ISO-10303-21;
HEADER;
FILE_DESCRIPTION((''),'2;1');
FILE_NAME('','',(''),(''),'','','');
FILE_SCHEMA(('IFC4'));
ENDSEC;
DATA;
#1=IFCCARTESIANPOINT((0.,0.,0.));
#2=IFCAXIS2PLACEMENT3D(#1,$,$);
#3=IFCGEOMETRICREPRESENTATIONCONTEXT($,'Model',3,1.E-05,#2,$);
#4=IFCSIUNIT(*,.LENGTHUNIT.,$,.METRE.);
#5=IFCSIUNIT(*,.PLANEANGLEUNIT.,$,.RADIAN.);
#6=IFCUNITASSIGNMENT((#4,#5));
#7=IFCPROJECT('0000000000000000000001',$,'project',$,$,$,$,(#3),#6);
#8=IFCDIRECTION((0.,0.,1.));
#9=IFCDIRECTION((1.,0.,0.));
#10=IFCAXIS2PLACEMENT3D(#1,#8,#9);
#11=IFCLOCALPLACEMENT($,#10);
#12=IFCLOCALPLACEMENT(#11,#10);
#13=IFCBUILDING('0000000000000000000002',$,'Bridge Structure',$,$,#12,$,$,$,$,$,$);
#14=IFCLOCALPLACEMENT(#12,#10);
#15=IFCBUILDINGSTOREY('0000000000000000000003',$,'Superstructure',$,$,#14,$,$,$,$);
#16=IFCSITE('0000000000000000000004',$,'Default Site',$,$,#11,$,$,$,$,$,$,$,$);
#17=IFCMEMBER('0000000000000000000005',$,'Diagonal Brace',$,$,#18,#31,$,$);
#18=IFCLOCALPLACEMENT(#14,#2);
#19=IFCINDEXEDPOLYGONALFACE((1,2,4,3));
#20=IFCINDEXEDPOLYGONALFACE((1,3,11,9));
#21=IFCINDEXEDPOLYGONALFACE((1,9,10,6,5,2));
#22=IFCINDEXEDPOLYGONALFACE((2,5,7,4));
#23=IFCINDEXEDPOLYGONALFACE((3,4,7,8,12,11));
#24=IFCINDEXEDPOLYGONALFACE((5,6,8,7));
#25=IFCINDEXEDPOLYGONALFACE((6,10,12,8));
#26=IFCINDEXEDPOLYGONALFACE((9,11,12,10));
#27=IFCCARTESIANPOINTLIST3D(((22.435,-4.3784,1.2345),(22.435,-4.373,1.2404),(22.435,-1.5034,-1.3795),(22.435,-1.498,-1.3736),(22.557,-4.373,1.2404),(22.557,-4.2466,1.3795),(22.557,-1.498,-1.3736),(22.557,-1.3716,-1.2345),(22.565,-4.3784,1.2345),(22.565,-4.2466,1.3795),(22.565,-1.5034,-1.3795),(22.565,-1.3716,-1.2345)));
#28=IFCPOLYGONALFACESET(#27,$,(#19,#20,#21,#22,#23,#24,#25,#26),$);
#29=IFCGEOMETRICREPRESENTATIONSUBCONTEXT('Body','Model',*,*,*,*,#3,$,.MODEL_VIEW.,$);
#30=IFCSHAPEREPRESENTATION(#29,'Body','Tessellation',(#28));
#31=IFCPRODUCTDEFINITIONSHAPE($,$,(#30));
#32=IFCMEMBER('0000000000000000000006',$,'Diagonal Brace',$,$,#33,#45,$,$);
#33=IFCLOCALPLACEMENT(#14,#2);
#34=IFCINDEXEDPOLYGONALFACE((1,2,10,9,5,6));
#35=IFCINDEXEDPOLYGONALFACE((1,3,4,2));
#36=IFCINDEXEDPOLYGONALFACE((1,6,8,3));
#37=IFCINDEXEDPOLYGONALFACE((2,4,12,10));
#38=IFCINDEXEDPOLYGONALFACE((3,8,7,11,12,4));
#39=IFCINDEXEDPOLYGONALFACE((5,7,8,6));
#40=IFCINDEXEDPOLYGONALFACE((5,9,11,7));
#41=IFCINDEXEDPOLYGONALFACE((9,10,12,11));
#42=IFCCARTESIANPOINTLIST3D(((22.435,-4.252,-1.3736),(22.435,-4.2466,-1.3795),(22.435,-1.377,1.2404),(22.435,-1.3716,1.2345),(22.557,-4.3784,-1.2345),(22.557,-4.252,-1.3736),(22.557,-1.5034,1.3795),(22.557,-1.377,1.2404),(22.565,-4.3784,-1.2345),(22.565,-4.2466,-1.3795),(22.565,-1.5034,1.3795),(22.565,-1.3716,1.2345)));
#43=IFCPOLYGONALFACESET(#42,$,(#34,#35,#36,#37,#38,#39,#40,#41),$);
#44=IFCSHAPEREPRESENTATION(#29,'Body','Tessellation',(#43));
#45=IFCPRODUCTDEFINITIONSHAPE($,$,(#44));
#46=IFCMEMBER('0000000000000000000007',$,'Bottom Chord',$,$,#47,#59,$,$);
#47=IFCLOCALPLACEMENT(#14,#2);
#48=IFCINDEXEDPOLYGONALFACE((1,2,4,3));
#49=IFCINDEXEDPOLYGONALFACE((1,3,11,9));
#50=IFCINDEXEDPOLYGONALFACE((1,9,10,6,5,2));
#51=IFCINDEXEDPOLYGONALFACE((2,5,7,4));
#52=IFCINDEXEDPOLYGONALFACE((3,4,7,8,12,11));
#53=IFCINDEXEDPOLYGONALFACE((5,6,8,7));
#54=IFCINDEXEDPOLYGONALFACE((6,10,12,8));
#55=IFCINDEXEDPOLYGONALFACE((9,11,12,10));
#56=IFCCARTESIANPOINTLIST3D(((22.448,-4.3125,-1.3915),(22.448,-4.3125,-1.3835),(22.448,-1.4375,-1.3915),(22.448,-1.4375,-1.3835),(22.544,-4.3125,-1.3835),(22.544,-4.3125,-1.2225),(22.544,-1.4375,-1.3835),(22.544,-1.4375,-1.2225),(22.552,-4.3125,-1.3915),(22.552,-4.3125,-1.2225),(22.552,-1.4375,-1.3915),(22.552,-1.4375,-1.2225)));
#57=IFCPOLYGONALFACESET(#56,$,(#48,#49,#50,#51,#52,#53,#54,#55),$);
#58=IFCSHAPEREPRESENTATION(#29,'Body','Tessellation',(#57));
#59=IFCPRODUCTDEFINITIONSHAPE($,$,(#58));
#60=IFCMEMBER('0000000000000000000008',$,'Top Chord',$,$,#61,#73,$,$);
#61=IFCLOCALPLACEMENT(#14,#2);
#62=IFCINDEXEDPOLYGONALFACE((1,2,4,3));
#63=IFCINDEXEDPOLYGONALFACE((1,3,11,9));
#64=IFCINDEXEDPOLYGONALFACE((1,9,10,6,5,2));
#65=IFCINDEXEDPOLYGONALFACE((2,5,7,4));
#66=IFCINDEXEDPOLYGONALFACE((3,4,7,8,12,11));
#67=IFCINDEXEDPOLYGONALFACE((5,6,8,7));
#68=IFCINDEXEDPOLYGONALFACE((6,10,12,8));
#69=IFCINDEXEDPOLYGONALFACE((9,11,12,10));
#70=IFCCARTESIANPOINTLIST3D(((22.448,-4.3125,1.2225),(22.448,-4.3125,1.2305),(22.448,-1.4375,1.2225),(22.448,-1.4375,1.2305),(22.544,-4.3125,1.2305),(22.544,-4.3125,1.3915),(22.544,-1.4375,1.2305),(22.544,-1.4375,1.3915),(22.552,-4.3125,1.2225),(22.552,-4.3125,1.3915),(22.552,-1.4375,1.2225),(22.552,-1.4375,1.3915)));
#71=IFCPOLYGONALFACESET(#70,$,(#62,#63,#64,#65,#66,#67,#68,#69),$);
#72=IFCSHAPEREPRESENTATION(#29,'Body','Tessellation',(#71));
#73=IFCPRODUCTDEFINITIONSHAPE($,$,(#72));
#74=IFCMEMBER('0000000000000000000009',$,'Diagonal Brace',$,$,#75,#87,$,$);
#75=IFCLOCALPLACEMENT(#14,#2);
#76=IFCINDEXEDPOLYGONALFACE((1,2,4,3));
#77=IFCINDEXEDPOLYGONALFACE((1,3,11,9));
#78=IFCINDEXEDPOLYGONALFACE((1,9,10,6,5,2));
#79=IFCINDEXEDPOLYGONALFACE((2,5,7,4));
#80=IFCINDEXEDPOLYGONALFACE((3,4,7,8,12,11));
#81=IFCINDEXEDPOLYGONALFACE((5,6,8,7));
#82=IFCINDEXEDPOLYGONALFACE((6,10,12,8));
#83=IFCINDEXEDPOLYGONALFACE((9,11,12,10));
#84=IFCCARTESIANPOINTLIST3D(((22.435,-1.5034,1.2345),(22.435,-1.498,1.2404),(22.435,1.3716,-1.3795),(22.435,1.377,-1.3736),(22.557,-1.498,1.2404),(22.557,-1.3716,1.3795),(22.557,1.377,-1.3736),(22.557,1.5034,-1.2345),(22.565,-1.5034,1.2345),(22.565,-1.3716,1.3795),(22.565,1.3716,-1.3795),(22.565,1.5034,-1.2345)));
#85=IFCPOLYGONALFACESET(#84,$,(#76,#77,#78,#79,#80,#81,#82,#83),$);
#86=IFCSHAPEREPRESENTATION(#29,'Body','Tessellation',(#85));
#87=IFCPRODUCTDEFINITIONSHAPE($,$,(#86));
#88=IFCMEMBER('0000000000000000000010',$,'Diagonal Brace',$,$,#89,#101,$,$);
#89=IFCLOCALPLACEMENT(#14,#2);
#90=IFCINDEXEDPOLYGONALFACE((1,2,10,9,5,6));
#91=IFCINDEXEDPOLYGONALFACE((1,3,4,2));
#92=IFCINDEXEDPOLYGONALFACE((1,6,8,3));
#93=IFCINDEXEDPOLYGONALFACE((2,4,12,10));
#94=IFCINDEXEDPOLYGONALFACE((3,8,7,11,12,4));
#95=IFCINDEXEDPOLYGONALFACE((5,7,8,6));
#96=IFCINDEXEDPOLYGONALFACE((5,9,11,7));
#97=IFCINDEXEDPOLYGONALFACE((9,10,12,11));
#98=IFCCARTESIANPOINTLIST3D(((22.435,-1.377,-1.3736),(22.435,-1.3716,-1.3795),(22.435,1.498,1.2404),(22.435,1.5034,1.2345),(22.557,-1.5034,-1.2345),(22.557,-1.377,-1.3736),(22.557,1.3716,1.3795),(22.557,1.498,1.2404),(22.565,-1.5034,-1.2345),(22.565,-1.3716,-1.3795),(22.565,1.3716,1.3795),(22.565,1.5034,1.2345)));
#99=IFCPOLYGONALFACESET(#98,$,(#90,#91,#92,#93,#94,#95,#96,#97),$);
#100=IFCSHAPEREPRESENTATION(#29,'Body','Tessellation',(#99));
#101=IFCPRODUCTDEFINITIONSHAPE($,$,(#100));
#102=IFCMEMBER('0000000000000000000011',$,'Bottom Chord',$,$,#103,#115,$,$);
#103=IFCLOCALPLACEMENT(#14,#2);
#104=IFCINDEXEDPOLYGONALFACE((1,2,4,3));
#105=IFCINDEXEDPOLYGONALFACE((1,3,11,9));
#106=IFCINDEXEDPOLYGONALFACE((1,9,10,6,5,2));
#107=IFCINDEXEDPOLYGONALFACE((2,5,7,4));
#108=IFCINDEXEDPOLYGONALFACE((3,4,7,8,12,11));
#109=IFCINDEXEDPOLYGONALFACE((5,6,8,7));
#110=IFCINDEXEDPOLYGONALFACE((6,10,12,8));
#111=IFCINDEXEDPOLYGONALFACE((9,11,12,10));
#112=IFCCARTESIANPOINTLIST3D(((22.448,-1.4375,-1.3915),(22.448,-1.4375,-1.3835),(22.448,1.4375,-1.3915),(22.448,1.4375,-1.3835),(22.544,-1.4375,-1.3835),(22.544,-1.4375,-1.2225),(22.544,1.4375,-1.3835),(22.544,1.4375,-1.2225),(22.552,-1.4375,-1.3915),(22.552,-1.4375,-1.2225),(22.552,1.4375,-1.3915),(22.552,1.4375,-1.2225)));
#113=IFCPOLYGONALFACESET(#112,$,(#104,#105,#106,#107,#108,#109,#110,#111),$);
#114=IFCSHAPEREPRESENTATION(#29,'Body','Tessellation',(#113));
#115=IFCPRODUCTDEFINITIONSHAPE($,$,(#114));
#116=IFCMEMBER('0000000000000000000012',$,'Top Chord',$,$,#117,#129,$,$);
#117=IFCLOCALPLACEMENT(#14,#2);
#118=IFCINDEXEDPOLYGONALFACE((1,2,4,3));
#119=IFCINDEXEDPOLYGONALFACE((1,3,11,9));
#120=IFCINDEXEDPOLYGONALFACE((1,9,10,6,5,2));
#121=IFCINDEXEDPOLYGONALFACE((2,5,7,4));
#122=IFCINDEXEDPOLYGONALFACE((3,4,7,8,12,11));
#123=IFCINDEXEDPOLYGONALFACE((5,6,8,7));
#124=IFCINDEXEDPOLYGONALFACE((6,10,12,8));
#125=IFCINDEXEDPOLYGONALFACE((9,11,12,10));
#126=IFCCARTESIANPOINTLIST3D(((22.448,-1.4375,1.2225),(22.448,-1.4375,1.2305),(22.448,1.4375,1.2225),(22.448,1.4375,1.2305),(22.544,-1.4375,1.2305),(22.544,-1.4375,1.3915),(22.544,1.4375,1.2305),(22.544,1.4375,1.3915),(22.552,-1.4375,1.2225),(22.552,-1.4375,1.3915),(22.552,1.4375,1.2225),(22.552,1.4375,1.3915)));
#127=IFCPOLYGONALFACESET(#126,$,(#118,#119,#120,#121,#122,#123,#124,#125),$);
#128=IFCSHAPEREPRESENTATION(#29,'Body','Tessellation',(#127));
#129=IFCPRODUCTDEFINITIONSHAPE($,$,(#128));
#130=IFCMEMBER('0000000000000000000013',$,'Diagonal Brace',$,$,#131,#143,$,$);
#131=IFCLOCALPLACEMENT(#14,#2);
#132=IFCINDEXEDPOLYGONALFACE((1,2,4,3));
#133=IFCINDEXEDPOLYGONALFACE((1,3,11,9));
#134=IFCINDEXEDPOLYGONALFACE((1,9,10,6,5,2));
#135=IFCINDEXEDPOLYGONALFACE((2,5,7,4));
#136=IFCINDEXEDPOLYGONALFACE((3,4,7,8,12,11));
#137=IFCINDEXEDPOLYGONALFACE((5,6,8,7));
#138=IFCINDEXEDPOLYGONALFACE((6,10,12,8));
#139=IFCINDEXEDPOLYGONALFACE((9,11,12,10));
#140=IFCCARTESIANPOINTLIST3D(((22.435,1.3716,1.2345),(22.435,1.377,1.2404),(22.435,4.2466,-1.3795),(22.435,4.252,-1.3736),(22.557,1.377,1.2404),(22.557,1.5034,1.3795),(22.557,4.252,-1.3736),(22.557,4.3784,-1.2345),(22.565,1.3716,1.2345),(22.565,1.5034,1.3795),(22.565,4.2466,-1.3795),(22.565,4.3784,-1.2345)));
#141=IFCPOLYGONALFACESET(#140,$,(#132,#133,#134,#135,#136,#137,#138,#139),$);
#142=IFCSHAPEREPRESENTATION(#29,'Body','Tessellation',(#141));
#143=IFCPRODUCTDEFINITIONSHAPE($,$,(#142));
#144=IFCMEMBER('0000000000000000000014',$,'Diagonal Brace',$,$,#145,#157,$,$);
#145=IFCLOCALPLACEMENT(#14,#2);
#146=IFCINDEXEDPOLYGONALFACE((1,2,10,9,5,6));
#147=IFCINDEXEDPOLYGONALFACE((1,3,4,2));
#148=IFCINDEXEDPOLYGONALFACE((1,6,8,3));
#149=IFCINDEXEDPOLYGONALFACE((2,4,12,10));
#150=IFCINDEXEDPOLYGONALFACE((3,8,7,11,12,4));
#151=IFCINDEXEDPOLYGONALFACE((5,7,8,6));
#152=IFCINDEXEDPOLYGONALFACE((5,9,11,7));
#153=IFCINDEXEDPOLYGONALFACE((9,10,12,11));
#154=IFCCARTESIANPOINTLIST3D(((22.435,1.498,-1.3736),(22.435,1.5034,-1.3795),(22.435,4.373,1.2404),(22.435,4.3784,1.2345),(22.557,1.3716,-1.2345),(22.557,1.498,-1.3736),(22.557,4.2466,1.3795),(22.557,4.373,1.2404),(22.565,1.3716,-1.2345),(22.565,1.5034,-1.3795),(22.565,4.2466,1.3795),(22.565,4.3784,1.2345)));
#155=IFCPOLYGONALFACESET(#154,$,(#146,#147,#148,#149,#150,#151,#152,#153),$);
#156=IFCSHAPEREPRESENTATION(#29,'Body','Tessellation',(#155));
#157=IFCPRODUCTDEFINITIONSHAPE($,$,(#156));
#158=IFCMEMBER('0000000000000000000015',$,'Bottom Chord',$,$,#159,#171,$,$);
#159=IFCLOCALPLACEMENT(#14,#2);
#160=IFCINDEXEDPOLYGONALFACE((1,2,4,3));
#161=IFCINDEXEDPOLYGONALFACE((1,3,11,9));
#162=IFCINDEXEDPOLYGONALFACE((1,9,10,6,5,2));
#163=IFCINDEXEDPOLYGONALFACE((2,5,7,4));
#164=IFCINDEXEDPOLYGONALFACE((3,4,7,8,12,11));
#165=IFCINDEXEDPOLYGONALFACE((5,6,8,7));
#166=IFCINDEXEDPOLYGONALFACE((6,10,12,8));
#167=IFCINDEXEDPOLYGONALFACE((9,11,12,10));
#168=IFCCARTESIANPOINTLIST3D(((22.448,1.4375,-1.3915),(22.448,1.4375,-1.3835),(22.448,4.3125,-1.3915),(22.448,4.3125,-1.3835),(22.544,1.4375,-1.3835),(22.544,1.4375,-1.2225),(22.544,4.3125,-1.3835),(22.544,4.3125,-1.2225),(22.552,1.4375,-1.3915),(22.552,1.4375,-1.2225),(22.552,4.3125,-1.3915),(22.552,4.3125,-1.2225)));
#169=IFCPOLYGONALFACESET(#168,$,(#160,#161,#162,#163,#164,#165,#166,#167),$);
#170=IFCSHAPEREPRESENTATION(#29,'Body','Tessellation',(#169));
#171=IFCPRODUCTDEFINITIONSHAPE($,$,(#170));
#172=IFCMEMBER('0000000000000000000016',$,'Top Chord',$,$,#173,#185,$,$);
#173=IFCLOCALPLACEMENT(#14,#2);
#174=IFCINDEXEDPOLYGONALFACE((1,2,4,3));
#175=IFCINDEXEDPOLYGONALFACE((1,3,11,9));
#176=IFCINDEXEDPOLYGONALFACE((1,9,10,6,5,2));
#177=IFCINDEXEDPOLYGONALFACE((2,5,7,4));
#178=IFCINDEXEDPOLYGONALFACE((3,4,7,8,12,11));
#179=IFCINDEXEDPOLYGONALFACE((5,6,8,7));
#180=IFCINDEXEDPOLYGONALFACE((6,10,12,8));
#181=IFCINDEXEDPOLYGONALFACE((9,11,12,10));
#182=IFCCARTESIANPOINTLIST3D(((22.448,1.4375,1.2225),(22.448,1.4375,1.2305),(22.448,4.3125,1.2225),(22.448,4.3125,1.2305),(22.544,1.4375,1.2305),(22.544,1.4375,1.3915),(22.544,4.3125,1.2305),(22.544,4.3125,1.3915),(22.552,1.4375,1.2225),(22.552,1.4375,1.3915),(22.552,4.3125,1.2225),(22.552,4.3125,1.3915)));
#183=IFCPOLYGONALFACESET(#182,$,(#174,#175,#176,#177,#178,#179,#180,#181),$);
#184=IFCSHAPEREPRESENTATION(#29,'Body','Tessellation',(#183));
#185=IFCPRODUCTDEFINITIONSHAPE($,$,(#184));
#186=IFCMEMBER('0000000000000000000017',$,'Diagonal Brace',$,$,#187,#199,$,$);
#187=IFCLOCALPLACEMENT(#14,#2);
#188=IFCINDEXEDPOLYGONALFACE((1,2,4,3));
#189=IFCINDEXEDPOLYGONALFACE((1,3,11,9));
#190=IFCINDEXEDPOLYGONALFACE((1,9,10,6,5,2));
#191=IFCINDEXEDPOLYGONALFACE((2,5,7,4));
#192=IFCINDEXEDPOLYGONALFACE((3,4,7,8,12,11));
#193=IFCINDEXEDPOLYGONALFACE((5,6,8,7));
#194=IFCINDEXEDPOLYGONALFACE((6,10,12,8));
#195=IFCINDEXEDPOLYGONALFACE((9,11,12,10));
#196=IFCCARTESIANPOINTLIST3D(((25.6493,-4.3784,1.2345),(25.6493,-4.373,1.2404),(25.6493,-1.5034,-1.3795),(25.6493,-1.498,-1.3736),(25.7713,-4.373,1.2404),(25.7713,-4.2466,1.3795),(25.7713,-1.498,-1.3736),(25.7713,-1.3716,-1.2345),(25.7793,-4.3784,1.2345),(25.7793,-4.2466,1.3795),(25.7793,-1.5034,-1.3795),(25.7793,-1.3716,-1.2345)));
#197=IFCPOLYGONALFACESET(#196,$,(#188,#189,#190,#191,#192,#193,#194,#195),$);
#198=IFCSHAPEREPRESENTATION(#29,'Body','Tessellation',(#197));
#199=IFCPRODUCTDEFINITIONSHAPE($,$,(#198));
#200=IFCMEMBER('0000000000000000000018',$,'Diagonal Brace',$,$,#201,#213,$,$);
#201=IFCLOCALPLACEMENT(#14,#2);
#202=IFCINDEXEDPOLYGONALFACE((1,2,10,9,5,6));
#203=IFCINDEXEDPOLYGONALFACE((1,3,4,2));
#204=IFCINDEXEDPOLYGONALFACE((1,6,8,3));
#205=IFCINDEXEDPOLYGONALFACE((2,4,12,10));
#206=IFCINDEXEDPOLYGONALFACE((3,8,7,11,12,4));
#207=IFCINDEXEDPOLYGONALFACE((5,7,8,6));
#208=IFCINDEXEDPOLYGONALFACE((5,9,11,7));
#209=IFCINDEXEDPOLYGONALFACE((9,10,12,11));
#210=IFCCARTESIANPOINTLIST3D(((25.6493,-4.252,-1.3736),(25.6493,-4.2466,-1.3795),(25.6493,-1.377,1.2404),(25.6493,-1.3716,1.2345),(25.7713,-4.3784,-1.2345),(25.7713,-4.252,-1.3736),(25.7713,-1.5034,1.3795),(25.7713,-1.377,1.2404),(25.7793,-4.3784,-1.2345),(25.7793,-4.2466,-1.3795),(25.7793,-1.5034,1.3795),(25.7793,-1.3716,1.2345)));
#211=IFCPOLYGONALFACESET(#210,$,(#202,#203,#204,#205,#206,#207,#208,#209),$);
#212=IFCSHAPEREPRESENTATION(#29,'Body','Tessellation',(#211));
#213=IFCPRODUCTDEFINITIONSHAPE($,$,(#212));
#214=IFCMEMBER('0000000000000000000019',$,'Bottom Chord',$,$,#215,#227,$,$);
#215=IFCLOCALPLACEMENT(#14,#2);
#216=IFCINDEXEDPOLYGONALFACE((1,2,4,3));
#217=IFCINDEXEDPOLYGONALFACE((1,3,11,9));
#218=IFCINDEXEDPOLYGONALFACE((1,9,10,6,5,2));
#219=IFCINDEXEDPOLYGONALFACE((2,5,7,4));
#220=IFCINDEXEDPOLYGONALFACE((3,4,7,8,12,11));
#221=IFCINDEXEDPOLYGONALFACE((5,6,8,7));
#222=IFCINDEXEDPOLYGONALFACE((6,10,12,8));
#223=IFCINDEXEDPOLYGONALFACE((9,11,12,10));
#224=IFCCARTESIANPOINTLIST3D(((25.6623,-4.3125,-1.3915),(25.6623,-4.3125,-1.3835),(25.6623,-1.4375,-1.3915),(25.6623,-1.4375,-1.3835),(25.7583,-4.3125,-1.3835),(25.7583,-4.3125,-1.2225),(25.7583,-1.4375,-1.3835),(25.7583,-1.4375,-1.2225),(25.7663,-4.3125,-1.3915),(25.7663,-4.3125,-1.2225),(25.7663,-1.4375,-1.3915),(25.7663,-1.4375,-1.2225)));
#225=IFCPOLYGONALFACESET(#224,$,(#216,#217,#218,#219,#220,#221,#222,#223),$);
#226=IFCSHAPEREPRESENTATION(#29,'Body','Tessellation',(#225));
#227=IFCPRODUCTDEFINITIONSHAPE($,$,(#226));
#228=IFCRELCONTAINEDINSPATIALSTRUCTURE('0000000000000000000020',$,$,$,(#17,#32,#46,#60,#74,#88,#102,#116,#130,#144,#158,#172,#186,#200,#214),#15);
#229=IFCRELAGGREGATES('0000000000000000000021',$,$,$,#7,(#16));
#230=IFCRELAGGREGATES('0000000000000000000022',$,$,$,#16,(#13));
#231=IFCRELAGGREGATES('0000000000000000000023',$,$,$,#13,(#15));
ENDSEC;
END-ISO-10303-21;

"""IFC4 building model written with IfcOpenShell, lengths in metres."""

from ifc_helpers import new_model, si_unit, frame, origin, origin_with_axes, origin_2d_with_axis, place, context, subcontext, project, spatial, l_section, extrude, element, save


model = new_model("IFC4")

# Units and contexts
model_context = context("Model", 3, precision=1e-05, world=origin())
body_context = subcontext(model_context, "Body", "Model", "MODEL_VIEW")
ifc_project = project(units=[si_unit("LENGTHUNIT", "METRE"), si_unit("PLANEANGLEUNIT", "RADIAN")], contexts=[model_context])

# Site, building, storey
site_placement = place(None, origin_with_axes())
site = spatial("IfcSite", under=ifc_project, at=site_placement, Name="Default Site")
building_placement = place(site_placement, origin_with_axes())
building = spatial("IfcBuilding", under=site, at=building_placement, Name="Bridge Structure")
storey_placement = place(building_placement, origin_with_axes())
storey = spatial("IfcBuildingStorey", under=building, at=storey_placement, Name="Superstructure")

# Members
for number, where, z_axis, x_axis, name in (
    (1, (22.5, -4.3125, 1.307), (0.0, 0.739893, -0.672724), (-1.0, 0.0, 0.0), "Diagonal Brace"),
    (2, (22.5, -4.3125, -1.307), (0.0, 0.739893, 0.672724), (-1.0, 0.0, 0.0), "Diagonal Brace"),
):
    element("IfcMember", number, at=place(storey_placement, frame(where, z_axis=z_axis, x_axis=x_axis)), inside=storey, Name=name, context=body_context, shape_type="SweptSolid", body=[
        extrude(l_section(Depth=0.196, Width=0.13, Thickness=0.008, at=origin_2d_with_axis()), origin_with_axes(), (0.0, 0.0, 1.0), 3.8857),
    ])
for number, where, z_axis, x_axis, name in (
    (3, (22.5, -4.3125, -1.307), (0.0, 1.0, 0.0), (-1.0, 0.0, 0.0), "Bottom Chord"),
    (4, (22.5, -4.3125, 1.307), (0.0, 1.0, 0.0), (-1.0, 0.0, 0.0), "Top Chord"),
):
    element("IfcMember", number, at=place(storey_placement, frame(where, z_axis=z_axis, x_axis=x_axis)), inside=storey, Name=name, context=body_context, shape_type="SweptSolid", body=[
        extrude(l_section(Depth=0.169, Width=0.104, Thickness=0.008, at=origin_2d_with_axis()), origin_with_axes(), (0.0, 0.0, 1.0), 2.875),
    ])
for number, where, z_axis, x_axis, name in (
    (5, (22.5, -1.4375, 1.307), (0.0, 0.739893, -0.672724), (-1.0, 0.0, 0.0), "Diagonal Brace"),
    (6, (22.5, -1.4375, -1.307), (0.0, 0.739893, 0.672724), (-1.0, 0.0, 0.0), "Diagonal Brace"),
):
    element("IfcMember", number, at=place(storey_placement, frame(where, z_axis=z_axis, x_axis=x_axis)), inside=storey, Name=name, context=body_context, shape_type="SweptSolid", body=[
        extrude(l_section(Depth=0.196, Width=0.13, Thickness=0.008, at=origin_2d_with_axis()), origin_with_axes(), (0.0, 0.0, 1.0), 3.8857),
    ])
for number, where, z_axis, x_axis, name in (
    (7, (22.5, -1.4375, -1.307), (0.0, 1.0, 0.0), (-1.0, 0.0, 0.0), "Bottom Chord"),
    (8, (22.5, -1.4375, 1.307), (0.0, 1.0, 0.0), (-1.0, 0.0, 0.0), "Top Chord"),
):
    element("IfcMember", number, at=place(storey_placement, frame(where, z_axis=z_axis, x_axis=x_axis)), inside=storey, Name=name, context=body_context, shape_type="SweptSolid", body=[
        extrude(l_section(Depth=0.169, Width=0.104, Thickness=0.008, at=origin_2d_with_axis()), origin_with_axes(), (0.0, 0.0, 1.0), 2.875),
    ])
for number, where, z_axis, x_axis, name in (
    (9, (22.5, 1.4375, 1.307), (0.0, 0.739893, -0.672724), (-1.0, 0.0, 0.0), "Diagonal Brace"),
    (10, (22.5, 1.4375, -1.307), (0.0, 0.739893, 0.672724), (-1.0, 0.0, 0.0), "Diagonal Brace"),
):
    element("IfcMember", number, at=place(storey_placement, frame(where, z_axis=z_axis, x_axis=x_axis)), inside=storey, Name=name, context=body_context, shape_type="SweptSolid", body=[
        extrude(l_section(Depth=0.196, Width=0.13, Thickness=0.008, at=origin_2d_with_axis()), origin_with_axes(), (0.0, 0.0, 1.0), 3.8857),
    ])
for number, where, z_axis, x_axis, name in (
    (11, (22.5, 1.4375, -1.307), (0.0, 1.0, 0.0), (-1.0, 0.0, 0.0), "Bottom Chord"),
    (12, (22.5, 1.4375, 1.307), (0.0, 1.0, 0.0), (-1.0, 0.0, 0.0), "Top Chord"),
):
    element("IfcMember", number, at=place(storey_placement, frame(where, z_axis=z_axis, x_axis=x_axis)), inside=storey, Name=name, context=body_context, shape_type="SweptSolid", body=[
        extrude(l_section(Depth=0.169, Width=0.104, Thickness=0.008, at=origin_2d_with_axis()), origin_with_axes(), (0.0, 0.0, 1.0), 2.875),
    ])
for number, where, z_axis, x_axis, name in (
    (13, (25.7143, -4.3125, 1.307), (0.0, 0.739893, -0.672724), (-1.0, 0.0, 0.0), "Diagonal Brace"),
    (14, (25.7143, -4.3125, -1.307), (0.0, 0.739893, 0.672724), (-1.0, 0.0, 0.0), "Diagonal Brace"),
):
    element("IfcMember", number, at=place(storey_placement, frame(where, z_axis=z_axis, x_axis=x_axis)), inside=storey, Name=name, context=body_context, shape_type="SweptSolid", body=[
        extrude(l_section(Depth=0.196, Width=0.13, Thickness=0.008, at=origin_2d_with_axis()), origin_with_axes(), (0.0, 0.0, 1.0), 3.8857),
    ])
for number, where, z_axis, x_axis, name in (
    (15, (25.7143, -4.3125, -1.307), (0.0, 1.0, 0.0), (-1.0, 0.0, 0.0), "Bottom Chord"),
):
    element("IfcMember", number, at=place(storey_placement, frame(where, z_axis=z_axis, x_axis=x_axis)), inside=storey, Name=name, context=body_context, shape_type="SweptSolid", body=[
        extrude(l_section(Depth=0.169, Width=0.104, Thickness=0.008, at=origin_2d_with_axis()), origin_with_axes(), (0.0, 0.0, 1.0), 2.875),
    ])

save(model, "model.ifc")
